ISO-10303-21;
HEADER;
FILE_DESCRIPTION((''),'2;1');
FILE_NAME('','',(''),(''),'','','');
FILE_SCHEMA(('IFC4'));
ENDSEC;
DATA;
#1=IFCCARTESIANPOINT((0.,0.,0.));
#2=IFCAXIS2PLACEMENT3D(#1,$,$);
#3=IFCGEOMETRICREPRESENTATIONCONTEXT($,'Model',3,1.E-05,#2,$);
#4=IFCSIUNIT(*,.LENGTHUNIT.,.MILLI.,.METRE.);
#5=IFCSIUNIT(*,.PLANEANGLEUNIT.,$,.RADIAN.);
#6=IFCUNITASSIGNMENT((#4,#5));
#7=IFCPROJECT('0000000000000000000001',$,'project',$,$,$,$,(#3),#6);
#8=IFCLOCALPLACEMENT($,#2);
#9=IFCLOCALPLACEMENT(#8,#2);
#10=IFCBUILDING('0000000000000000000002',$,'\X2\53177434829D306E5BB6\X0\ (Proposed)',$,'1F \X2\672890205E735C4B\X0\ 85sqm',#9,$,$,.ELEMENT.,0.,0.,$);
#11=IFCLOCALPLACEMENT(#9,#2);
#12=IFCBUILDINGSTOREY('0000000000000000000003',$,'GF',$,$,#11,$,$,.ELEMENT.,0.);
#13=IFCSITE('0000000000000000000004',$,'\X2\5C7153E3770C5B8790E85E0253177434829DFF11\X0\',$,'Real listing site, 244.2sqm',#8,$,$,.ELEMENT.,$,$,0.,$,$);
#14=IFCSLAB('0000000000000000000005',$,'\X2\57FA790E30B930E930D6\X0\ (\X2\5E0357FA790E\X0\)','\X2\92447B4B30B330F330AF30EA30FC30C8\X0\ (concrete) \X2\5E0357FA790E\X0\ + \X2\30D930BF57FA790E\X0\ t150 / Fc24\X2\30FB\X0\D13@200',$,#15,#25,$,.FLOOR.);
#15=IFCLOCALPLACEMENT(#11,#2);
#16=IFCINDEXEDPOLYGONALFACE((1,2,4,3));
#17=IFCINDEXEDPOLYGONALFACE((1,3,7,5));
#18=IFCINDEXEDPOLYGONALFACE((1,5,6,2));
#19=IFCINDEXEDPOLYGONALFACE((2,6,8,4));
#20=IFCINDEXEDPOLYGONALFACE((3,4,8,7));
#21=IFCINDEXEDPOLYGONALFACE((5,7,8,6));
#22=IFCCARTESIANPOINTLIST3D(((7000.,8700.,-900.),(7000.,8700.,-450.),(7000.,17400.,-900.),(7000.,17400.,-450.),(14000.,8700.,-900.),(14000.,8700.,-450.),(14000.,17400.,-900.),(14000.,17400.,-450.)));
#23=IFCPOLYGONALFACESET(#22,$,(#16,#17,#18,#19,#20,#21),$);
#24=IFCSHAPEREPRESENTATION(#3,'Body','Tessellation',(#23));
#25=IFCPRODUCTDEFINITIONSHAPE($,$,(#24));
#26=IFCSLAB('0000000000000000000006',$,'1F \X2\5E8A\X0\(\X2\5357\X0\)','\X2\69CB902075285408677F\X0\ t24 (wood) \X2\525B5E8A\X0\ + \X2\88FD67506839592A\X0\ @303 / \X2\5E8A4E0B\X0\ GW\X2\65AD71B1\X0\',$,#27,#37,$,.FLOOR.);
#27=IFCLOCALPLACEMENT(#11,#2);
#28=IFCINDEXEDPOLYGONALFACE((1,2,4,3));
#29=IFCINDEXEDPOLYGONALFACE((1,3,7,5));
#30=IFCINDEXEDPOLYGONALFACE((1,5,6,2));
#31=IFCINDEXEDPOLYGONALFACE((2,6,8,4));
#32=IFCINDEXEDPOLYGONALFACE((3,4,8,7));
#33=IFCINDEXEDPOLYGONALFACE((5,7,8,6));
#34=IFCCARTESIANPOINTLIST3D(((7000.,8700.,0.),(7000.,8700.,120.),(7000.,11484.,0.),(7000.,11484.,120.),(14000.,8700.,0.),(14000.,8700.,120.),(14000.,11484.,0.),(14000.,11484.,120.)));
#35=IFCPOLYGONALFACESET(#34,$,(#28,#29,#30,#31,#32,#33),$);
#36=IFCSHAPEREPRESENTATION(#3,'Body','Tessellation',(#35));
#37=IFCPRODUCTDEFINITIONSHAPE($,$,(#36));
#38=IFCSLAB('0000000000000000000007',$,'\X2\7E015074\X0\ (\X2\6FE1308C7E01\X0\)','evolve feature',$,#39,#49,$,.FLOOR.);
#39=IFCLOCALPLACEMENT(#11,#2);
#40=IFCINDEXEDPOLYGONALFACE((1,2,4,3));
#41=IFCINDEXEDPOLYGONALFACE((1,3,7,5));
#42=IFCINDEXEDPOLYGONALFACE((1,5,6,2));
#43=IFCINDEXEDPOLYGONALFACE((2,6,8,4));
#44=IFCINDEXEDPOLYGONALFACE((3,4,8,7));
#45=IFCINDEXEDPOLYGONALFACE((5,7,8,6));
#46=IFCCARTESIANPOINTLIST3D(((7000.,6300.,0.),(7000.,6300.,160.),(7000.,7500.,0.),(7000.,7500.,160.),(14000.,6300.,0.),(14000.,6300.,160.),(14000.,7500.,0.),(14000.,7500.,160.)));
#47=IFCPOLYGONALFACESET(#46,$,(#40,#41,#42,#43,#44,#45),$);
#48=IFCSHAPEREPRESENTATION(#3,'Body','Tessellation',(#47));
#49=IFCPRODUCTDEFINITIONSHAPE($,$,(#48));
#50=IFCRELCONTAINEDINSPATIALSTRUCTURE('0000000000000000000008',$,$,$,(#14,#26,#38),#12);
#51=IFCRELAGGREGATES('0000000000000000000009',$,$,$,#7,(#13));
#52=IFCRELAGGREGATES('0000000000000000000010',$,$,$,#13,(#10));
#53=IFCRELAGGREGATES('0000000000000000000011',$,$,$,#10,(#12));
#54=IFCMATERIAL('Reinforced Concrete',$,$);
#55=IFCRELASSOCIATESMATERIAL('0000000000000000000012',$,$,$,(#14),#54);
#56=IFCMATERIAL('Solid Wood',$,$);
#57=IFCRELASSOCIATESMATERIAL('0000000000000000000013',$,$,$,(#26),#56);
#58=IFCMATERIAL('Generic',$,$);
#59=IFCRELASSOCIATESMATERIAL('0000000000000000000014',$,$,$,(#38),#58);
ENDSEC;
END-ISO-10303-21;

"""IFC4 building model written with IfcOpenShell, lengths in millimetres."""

from ifc_helpers import new_model, si_unit, frame, frame_2d, origin, place, context, project, spatial, rectangle, extrude, material, element, save


model = new_model("IFC4")

# Units and contexts
model_context = context("Model", 3, precision=1e-05, world=origin())
ifc_project = project(units=[si_unit("LENGTHUNIT", "METRE", prefix="MILLI"), si_unit("PLANEANGLEUNIT", "RADIAN")], contexts=[model_context])

# Site, building, storey
site_placement = place(None, origin())
site = spatial("IfcSite", under=ifc_project, at=site_placement, Name="山口県宇部市北琴芝１", ObjectType="Real listing site, 244.2sqm", CompositionType="ELEMENT", RefElevation=0.0)
building_placement = place(site_placement, origin())
building = spatial("IfcBuilding", under=site, at=building_placement, Name="北琴芝の家 (Proposed)", ObjectType="1F 木造平屋 85sqm", CompositionType="ELEMENT", ElevationOfRefHeight=0.0, ElevationOfTerrain=0.0)
storey_placement = place(building_placement, origin())
storey = spatial("IfcBuildingStorey", under=building, at=storey_placement, Name="GF", CompositionType="ELEMENT", Elevation=0.0)

# Slabs
ifc_material_1 = material(Name="Reinforced Concrete")
slab_1_placement = place(storey_placement, frame((3500.0, 4350.0, -450.0)))
element("IfcSlab", 1, at=slab_1_placement, inside=storey, material=ifc_material_1, Name="基礎スラブ (布基礎)", Description="鉄筋コンクリート (concrete) 布基礎 + ベタ基礎 t150 / Fc24・D13@200", PredefinedType="FLOOR", context=model_context, shape_type="SweptSolid", body=[
    extrude(rectangle(XDim=7000.0, YDim=8700.0, at=frame_2d((3500.0, 4350.0))), frame((3500.0, 4350.0, -450.0)), (0.0, 0.0, 1.0), 450.0),
])
ifc_material_2 = material(Name="Solid Wood")
slab_2_placement = place(storey_placement, frame((3500.0, 4350.0, 0.0)))
element("IfcSlab", 2, at=slab_2_placement, inside=storey, material=ifc_material_2, Name="1F 床(南)", Description="構造用合板 t24 (wood) 剛床 + 製材根太 @303 / 床下 GW断熱", PredefinedType="FLOOR", context=model_context, shape_type="SweptSolid", body=[
    extrude(rectangle(XDim=7000.0, YDim=2784.0, at=frame_2d((3500.0, 1392.0))), frame((3500.0, 4350.0, 0.0)), (0.0, 0.0, 1.0), 120.0),
])
ifc_material_3 = material(Name="Generic")
slab_3_placement = place(storey_placement, frame((3500.0, 3150.0, 0.0)))
element("IfcSlab", 3, at=slab_3_placement, inside=storey, material=ifc_material_3, Name="縁側 (濡れ縁)", Description="evolve feature", PredefinedType="FLOOR", context=model_context, shape_type="SweptSolid", body=[
    extrude(rectangle(XDim=7000.0, YDim=1200.0, at=frame_2d((3500.0, 600.0))), frame((3500.0, 3150.0, 0.0)), (0.0, 0.0, 1.0), 160.0),
])

save(model, "model.ifc")
